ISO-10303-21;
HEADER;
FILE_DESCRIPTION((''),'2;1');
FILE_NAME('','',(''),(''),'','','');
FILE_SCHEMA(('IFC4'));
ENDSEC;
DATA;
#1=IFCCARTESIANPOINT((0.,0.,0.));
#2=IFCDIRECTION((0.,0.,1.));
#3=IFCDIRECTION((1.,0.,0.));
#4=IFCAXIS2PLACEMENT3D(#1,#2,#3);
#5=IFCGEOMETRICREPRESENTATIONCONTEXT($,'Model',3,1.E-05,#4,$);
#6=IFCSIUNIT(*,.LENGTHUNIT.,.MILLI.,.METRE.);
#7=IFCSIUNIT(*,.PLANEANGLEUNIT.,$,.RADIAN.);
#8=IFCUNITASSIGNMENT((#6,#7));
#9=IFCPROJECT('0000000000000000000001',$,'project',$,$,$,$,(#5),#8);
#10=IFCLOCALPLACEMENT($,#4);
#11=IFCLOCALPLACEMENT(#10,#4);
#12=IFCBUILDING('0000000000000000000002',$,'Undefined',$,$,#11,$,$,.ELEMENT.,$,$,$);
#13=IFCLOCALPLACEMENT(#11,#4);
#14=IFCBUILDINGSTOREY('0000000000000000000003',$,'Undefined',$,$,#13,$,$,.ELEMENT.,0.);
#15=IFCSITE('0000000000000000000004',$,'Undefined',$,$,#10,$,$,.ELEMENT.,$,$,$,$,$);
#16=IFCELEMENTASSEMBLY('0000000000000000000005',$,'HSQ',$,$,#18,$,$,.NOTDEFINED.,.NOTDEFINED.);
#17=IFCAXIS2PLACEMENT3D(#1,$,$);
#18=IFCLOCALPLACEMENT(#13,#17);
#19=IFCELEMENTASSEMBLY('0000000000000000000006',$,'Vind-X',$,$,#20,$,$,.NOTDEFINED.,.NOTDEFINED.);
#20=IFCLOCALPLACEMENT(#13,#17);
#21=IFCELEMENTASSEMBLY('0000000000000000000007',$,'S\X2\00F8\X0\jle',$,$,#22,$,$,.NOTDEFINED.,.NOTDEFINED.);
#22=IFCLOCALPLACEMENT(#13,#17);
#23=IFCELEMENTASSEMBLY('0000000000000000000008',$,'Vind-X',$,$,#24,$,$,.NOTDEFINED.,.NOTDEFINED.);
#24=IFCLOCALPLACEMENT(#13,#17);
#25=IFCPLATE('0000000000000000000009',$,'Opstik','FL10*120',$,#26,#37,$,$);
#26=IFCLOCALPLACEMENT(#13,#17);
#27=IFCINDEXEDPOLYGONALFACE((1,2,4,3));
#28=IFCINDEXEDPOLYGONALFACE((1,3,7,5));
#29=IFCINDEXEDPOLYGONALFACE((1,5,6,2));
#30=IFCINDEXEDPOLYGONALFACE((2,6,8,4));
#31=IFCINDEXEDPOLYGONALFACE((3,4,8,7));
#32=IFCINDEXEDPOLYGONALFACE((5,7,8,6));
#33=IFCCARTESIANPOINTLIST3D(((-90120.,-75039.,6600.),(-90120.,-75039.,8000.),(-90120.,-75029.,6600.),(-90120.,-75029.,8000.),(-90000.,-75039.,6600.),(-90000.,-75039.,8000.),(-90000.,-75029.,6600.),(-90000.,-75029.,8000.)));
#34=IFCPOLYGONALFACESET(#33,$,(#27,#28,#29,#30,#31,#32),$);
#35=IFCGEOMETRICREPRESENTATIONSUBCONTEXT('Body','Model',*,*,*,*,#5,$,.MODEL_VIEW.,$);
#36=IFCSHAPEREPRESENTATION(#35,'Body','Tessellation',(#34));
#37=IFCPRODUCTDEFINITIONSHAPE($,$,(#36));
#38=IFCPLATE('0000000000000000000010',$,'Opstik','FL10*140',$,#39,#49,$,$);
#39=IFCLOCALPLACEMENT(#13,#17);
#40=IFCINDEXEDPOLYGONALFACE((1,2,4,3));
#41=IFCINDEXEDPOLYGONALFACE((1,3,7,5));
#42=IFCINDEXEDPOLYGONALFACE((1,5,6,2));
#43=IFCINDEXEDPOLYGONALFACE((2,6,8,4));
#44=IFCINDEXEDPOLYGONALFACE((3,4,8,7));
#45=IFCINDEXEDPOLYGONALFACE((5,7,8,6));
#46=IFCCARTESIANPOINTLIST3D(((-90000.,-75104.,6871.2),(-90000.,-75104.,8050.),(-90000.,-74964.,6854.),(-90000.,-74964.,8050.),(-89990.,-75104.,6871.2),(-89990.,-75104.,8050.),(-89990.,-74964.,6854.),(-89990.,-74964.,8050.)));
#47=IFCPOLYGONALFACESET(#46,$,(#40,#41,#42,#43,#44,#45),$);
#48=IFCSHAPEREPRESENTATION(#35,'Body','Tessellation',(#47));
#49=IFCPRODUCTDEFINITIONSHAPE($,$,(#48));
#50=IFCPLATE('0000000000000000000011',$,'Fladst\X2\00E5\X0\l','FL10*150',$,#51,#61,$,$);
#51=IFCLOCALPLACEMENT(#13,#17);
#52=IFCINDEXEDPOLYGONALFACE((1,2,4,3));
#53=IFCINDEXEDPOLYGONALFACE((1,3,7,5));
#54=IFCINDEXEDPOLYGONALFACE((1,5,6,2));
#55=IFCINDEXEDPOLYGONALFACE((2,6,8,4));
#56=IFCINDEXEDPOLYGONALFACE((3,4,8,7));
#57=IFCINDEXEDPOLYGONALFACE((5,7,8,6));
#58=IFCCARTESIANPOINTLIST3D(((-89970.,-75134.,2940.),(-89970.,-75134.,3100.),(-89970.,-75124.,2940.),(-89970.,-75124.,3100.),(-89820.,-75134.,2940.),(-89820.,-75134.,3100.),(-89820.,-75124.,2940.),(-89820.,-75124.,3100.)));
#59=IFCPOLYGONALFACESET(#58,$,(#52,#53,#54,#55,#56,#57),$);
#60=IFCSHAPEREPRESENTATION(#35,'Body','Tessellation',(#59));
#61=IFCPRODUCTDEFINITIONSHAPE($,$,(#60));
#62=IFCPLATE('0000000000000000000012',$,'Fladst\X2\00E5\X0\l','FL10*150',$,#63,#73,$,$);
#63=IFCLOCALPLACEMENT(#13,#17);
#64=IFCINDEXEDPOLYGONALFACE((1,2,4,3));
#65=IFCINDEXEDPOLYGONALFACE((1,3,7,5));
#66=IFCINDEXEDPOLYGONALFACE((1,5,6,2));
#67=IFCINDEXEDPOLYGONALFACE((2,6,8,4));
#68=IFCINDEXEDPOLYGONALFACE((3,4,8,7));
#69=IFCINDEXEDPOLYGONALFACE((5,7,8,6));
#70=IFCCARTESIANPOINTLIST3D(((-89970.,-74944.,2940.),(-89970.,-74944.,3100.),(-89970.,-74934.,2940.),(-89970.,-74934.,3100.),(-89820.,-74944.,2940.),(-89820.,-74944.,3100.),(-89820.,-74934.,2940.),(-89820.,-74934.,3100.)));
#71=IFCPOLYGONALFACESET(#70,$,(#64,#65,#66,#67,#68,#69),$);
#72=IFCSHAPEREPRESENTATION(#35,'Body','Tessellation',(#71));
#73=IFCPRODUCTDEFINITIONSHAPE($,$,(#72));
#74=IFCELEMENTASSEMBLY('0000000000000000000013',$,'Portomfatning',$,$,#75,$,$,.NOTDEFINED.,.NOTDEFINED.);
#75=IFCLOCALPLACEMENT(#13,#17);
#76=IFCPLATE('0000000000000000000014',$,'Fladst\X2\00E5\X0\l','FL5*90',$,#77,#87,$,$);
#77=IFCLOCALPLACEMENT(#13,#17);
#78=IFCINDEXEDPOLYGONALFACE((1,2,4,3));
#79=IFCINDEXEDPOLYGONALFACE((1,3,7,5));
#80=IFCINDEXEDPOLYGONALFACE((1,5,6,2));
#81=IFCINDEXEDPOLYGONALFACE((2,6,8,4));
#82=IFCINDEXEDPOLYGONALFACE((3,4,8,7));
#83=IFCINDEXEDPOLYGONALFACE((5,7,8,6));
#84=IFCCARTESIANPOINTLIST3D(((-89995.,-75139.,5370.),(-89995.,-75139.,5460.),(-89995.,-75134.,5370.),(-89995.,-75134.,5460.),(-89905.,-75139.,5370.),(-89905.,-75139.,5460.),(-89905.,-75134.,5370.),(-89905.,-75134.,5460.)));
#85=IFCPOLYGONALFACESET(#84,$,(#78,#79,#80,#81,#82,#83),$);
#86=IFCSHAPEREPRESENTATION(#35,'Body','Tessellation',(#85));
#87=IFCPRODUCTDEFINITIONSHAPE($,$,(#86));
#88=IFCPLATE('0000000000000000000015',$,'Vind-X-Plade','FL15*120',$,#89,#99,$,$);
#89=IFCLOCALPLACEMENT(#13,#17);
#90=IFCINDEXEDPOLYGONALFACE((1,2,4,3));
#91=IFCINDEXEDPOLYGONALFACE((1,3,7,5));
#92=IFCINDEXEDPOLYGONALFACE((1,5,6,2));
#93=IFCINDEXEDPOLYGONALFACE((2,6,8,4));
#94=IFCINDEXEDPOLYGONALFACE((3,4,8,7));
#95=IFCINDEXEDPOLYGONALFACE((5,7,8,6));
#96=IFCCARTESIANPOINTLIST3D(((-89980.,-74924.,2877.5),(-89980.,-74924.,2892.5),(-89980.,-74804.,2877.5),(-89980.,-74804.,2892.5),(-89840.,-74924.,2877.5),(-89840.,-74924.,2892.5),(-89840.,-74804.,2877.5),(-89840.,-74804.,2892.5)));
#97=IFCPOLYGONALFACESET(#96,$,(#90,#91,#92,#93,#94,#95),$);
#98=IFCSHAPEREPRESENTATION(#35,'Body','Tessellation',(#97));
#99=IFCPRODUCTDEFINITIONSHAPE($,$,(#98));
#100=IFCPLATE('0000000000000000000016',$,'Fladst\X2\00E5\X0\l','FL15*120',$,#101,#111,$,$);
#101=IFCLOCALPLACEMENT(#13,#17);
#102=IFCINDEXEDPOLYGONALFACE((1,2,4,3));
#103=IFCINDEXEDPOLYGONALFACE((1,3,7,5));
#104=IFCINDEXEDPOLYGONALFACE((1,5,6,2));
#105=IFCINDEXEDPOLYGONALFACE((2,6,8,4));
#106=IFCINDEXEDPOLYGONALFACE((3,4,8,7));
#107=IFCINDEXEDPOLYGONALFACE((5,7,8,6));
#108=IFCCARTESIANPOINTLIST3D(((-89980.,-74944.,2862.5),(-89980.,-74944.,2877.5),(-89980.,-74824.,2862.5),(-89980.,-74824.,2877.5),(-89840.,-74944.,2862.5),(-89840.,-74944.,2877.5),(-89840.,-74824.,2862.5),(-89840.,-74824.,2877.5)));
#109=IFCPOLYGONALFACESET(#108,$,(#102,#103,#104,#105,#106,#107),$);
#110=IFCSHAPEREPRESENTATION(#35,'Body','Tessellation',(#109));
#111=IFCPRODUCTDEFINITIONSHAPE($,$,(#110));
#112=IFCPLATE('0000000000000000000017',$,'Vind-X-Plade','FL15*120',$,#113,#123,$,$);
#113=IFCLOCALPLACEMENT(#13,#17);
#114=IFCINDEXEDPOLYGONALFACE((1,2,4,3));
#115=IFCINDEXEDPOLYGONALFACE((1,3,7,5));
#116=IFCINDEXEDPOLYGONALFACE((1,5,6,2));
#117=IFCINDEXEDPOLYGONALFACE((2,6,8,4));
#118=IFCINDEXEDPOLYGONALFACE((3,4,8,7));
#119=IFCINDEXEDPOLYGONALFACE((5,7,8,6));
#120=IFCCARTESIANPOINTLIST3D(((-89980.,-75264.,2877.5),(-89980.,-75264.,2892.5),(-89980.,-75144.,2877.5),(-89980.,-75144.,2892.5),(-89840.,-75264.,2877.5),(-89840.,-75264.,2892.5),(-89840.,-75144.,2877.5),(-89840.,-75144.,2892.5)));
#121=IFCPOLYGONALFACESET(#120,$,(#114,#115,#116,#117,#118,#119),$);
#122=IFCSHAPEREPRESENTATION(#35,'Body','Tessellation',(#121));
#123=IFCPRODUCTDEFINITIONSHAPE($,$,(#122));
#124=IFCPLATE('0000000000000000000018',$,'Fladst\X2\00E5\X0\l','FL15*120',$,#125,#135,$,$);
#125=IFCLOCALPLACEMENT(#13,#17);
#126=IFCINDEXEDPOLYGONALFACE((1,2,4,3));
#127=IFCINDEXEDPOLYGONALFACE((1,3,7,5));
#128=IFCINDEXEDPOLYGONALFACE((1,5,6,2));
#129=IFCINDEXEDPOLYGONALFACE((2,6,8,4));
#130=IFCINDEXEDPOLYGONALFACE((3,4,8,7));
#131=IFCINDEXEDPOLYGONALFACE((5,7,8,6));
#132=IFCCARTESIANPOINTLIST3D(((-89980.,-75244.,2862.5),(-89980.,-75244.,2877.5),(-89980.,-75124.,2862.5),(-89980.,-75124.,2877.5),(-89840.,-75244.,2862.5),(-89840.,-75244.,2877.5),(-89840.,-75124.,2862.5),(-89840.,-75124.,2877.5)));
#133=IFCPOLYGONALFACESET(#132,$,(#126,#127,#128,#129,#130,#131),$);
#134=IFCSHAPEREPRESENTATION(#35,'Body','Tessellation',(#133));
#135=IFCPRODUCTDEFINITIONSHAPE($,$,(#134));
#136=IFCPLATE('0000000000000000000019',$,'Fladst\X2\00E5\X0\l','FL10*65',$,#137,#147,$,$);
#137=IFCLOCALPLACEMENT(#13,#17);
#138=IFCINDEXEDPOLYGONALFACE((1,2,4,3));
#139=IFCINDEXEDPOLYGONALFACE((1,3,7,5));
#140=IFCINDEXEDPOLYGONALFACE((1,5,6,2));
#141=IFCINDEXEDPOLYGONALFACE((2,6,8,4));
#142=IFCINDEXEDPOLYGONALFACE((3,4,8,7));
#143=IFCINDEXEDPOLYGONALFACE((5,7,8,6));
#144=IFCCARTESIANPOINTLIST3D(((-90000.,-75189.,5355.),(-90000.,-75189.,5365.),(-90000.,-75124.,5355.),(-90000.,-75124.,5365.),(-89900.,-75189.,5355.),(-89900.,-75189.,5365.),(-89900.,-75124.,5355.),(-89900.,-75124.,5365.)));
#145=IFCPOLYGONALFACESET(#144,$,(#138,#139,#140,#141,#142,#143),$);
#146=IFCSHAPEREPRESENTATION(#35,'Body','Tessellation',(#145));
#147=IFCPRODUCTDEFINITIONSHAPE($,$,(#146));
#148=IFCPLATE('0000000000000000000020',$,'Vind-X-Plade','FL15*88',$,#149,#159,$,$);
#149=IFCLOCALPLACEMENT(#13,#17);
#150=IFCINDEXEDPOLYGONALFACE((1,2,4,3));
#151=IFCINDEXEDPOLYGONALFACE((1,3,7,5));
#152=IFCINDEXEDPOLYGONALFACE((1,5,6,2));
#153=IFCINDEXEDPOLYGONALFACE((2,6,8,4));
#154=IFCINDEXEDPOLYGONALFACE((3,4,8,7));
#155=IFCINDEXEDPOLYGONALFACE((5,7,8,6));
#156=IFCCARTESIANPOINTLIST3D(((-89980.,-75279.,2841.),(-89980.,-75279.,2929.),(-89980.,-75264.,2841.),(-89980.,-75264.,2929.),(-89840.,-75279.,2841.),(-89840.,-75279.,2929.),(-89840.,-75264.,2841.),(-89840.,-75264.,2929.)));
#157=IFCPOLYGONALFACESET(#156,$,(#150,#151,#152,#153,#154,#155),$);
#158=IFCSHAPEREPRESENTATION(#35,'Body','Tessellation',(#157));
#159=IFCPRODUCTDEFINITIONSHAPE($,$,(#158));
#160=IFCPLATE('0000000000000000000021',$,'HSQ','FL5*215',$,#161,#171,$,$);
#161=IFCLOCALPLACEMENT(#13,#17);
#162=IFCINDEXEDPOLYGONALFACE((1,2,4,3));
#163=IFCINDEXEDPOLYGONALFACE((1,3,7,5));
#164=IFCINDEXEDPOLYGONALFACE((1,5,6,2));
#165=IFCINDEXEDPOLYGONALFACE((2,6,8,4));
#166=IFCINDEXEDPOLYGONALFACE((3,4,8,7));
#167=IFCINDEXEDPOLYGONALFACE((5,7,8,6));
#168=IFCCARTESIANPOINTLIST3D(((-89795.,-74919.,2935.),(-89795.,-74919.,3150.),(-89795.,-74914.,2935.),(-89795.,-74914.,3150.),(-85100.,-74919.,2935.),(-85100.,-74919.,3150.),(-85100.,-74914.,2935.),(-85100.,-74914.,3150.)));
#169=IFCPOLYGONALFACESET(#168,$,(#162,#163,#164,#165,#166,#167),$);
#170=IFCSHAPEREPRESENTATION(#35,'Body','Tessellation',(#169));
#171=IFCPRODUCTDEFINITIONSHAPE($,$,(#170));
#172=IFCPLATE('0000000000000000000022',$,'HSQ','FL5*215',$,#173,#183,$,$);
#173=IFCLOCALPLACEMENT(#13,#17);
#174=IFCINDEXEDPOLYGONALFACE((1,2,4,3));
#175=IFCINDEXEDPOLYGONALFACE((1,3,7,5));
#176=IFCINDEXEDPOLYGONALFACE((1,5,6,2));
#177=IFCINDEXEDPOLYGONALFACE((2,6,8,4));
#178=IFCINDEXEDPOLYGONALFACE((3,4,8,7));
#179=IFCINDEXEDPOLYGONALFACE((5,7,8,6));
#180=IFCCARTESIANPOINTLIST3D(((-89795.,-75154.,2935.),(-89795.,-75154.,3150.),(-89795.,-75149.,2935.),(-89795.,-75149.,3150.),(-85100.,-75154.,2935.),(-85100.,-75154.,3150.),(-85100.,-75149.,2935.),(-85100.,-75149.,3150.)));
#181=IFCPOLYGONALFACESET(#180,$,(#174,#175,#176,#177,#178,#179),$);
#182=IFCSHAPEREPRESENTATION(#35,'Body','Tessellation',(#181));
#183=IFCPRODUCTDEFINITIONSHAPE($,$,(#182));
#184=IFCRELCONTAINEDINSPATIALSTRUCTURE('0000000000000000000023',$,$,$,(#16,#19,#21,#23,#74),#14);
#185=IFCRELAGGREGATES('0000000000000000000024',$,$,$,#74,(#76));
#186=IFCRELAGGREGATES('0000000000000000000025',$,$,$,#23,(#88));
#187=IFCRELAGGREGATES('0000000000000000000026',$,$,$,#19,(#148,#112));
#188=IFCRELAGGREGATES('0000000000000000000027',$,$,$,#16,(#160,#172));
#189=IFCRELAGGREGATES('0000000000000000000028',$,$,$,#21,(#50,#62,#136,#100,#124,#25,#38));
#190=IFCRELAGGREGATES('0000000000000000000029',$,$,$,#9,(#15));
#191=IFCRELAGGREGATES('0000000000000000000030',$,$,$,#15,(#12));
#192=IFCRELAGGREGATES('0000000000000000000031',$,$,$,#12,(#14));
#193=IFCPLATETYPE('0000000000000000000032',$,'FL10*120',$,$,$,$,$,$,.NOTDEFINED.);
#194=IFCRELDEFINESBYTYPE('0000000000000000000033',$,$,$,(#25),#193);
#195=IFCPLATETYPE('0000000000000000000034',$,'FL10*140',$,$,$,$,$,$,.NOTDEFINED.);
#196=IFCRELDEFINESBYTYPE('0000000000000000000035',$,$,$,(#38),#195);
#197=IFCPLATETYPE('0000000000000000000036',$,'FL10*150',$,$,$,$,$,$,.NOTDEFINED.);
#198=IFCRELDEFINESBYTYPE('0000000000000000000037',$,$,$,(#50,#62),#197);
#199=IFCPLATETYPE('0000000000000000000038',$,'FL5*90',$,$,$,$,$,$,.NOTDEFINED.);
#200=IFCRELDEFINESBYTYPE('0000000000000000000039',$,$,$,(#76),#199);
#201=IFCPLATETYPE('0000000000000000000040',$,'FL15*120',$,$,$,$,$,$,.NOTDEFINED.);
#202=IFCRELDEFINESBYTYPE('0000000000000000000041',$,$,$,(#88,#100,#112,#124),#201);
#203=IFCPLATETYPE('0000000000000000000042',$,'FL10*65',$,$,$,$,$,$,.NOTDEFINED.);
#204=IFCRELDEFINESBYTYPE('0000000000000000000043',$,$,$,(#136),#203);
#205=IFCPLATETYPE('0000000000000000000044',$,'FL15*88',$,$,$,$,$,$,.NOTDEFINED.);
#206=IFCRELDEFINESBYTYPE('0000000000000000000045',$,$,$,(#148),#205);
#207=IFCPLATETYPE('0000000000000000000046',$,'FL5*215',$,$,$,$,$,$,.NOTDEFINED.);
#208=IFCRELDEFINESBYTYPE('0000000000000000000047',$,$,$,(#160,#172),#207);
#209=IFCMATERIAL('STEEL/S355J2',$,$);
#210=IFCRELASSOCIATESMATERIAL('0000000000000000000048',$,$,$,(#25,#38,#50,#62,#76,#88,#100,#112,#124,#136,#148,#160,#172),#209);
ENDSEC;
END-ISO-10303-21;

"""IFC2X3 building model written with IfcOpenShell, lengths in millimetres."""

from ifc_helpers import new_model, si_unit, frame, origin_with_axes, place, context, subcontext, project, spatial, polyline, outline, extrude, material, type_object, element, aggregate, save


model = new_model("IFC2X3")

# Units and contexts
model_context = context("Model", 3, precision=1e-05, world=origin_with_axes())
body_context = subcontext(model_context, "Body", "Model", "MODEL_VIEW")
ifc_project = project(units=[si_unit("LENGTHUNIT", "METRE", prefix="MILLI"), si_unit("PLANEANGLEUNIT", "RADIAN")], contexts=[model_context])

# Site, building, storey
site_placement = place(None, origin_with_axes())
site = spatial("IfcSite", under=ifc_project, at=site_placement, Name="Undefined", CompositionType="ELEMENT")
building_placement = place(site_placement, origin_with_axes())
building = spatial("IfcBuilding", under=site, at=building_placement, Name="Undefined", CompositionType="ELEMENT")
storey_placement = place(building_placement, origin_with_axes())
storey = spatial("IfcBuildingStorey", under=building, at=storey_placement, Name="Undefined", CompositionType="ELEMENT", Elevation=0.0)

# Element assembly
assembly_1_placement = place(storey_placement, origin_with_axes())
assembly_1 = element("IfcElementAssembly", 1, at=assembly_1_placement, inside=storey, Name="HSQ", AssemblyPlace="NOTDEFINED", PredefinedType="NOTDEFINED")

# Element assembly
assembly_2_placement = place(storey_placement, origin_with_axes())
assembly_2 = element("IfcElementAssembly", 2, at=assembly_2_placement, inside=storey, Name="Vind-X", AssemblyPlace="NOTDEFINED", PredefinedType="NOTDEFINED")

# Element assembly
assembly_3_placement = place(storey_placement, origin_with_axes())
assembly_3 = element("IfcElementAssembly", 3, at=assembly_3_placement, inside=storey, Name="Søjle", AssemblyPlace="NOTDEFINED", PredefinedType="NOTDEFINED")

# Element assembly
assembly_4_placement = place(storey_placement, origin_with_axes())
assembly_4 = element("IfcElementAssembly", 4, at=assembly_4_placement, inside=storey, Name="Vind-X", AssemblyPlace="NOTDEFINED", PredefinedType="NOTDEFINED")

# Shared definitions
ifc_material_1 = material(Name="STEEL/S355J2")

# Plates
plate_type_1 = type_object("IfcPlateType", Name="FL10*120", PredefinedType="NOTDEFINED")
plate_1_placement = place(assembly_3_placement, frame((-90000.0, -75034.0, 6600.0), z_axis=(0.0, -1.0, 0.0), x_axis=(0.0, 0.0, 1.0)))
plate_1 = element("IfcPlate", 5, at=plate_1_placement, type_object=plate_type_1, material=ifc_material_1, Name="Opstik", Description="FL10*120", context=body_context, shape_type="SweptSolid", body=[
    extrude(outline(polyline([(0.0, 0.0), (1400.0, 0.0), (1400.0, 120.0), (1400.0, 120.0), (0.0, 120.0), (0.0, 120.0), (0.0, 0.0)])), frame((0.0, 0.0, -5.0), z_axis=(0.0, 0.0, 1.0), x_axis=(1.0, 0.0, 0.0)), (0.0, 0.0, 1.0), 10.0),
])
plate_type_2 = type_object("IfcPlateType", Name="FL10*140", PredefinedType="NOTDEFINED")
plate_2_placement = place(assembly_3_placement, frame((-89995.0, -75104.0, 6871.2), z_axis=(-1.0, 0.0, 0.0), x_axis=(0.0, 0.0, 1.0)))
plate_2 = element("IfcPlate", 6, at=plate_2_placement, type_object=plate_type_2, material=ifc_material_1, Name="Opstik", Description="FL10*140", context=body_context, shape_type="SweptSolid", body=[
    extrude(outline(polyline([(0.0, 0.0), (1178.8, 0.0), (1178.8, 0.0), (1178.8, 140.0), (1178.8, 140.0), (-17.2, 140.0), (0.0, 0.0)])), frame((0.0, 0.0, -5.0), z_axis=(0.0, 0.0, 1.0), x_axis=(1.0, 0.0, 0.0)), (0.0, 0.0, 1.0), 10.0),
])
plate_type_3 = type_object("IfcPlateType", Name="FL10*150", PredefinedType="NOTDEFINED")
plate_3_placement = place(assembly_3_placement, frame((-89820.0, -75129.0, 3100.0), z_axis=(0.0, -1.0, 0.0), x_axis=(-1.0, 0.0, 0.0)))
plate_3 = element("IfcPlate", 7, at=plate_3_placement, type_object=plate_type_3, material=ifc_material_1, Name="Fladstål", Description="FL10*150", context=body_context, shape_type="SweptSolid", body=[
    extrude(outline(polyline([(0.0, 0.0), (150.0, 0.0), (150.0, 160.0), (0.0, 160.0), (0.0, 0.0)])), frame((0.0, 0.0, -5.0), z_axis=(0.0, 0.0, 1.0), x_axis=(1.0, 0.0, 0.0)), (0.0, 0.0, 1.0), 10.0),
])
plate_4_placement = place(assembly_3_placement, frame((-89820.0, -74939.0, 3100.0), z_axis=(0.0, -1.0, 0.0), x_axis=(-1.0, 0.0, 0.0)))
plate_4 = element("IfcPlate", 8, at=plate_4_placement, type_object=plate_type_3, material=ifc_material_1, Name="Fladstål", Description="FL10*150", context=body_context, shape_type="SweptSolid", body=[
    extrude(outline(polyline([(0.0, 0.0), (150.0, 0.0), (150.0, 160.0), (0.0, 160.0), (0.0, 0.0)])), frame((0.0, 0.0, -5.0), z_axis=(0.0, 0.0, 1.0), x_axis=(1.0, 0.0, 0.0)), (0.0, 0.0, 1.0), 10.0),
])

# Element assembly, plate
assembly_5_placement = place(storey_placement, origin_with_axes())
assembly_5 = element("IfcElementAssembly", 9, at=assembly_5_placement, inside=storey, Name="Portomfatning", AssemblyPlace="NOTDEFINED", PredefinedType="NOTDEFINED")
plate_type_4 = type_object("IfcPlateType", Name="FL5*90", PredefinedType="NOTDEFINED")
plate_5_placement = place(assembly_5_placement, frame((-89995.0, -75136.5, 5370.0), z_axis=(0.000185, 1.0, 0.0), x_axis=(0.0, 0.0, 1.0)))
plate_5 = element("IfcPlate", 10, at=plate_5_placement, type_object=plate_type_4, material=ifc_material_1, Name="Fladstål", Description="FL5*90", context=body_context, shape_type="SweptSolid", body=[
    extrude(outline(polyline([(0.0, 0.0), (90.0, 0.0), (90.0, 90.0), (0.0, 90.0), (0.0, 0.0)])), frame((0.0, 0.0, -2.5), z_axis=(0.0, 0.0, 1.0), x_axis=(1.0, 0.0, 0.0)), (0.0, 0.0, 1.0), 5.0),
])
aggregate(assembly_5, [plate_5])

# Plates
plate_type_5 = type_object("IfcPlateType", Name="FL15*120", PredefinedType="NOTDEFINED")
plate_6_placement = place(assembly_4_placement, frame((-89910.0, -74924.0, 2885.0), z_axis=(0.0, 0.0, -1.0), x_axis=(0.0, 1.0, 0.0)))
plate_6 = element("IfcPlate", 11, at=plate_6_placement, type_object=plate_type_5, material=ifc_material_1, Name="Vind-X-Plade", Description="FL15*120", context=body_context, shape_type="SweptSolid", body=[
    extrude(outline(polyline([(0.0, -70.0), (0.0, 70.0), (120.0, 70.0), (120.0, -70.0), (0.0, -70.0)])), frame((0.0, 0.0, -7.5), z_axis=(0.0, 0.0, 1.0), x_axis=(1.0, 0.0, 0.0)), (0.0, 0.0, 1.0), 15.0),
])
plate_7_placement = place(assembly_3_placement, frame((-89980.0, -74944.0, 2870.0), z_axis=(0.0, 0.0, 1.0), x_axis=(1.0, 0.0, 0.0)))
plate_7 = element("IfcPlate", 12, at=plate_7_placement, type_object=plate_type_5, material=ifc_material_1, Name="Fladstål", Description="FL15*120", context=body_context, shape_type="SweptSolid", body=[
    extrude(outline(polyline([(0.0, 0.0), (140.0, 0.0), (140.0, 120.0), (0.0, 120.0), (0.0, 0.0)])), frame((0.0, 0.0, -7.5), z_axis=(0.0, 0.0, 1.0), x_axis=(1.0, 0.0, 0.0)), (0.0, 0.0, 1.0), 15.0),
])
plate_8_placement = place(assembly_2_placement, frame((-89910.0, -75144.0, 2885.0), z_axis=(0.0, 0.0, -1.0), x_axis=(0.0, -1.0, 0.0)))
plate_8 = element("IfcPlate", 13, at=plate_8_placement, type_object=plate_type_5, material=ifc_material_1, Name="Vind-X-Plade", Description="FL15*120", context=body_context, shape_type="SweptSolid", body=[
    extrude(outline(polyline([(0.0, -70.0), (0.0, 70.0), (120.0, 70.0), (120.0, -70.0), (0.0, -70.0)])), frame((0.0, 0.0, -7.5), z_axis=(0.0, 0.0, 1.0), x_axis=(1.0, 0.0, 0.0)), (0.0, 0.0, 1.0), 15.0),
])
plate_9_placement = place(assembly_3_placement, frame((-89840.0, -75124.0, 2870.0), z_axis=(0.0, 0.0, 1.0), x_axis=(-1.0, 0.0, 0.0)))
plate_9 = element("IfcPlate", 14, at=plate_9_placement, type_object=plate_type_5, material=ifc_material_1, Name="Fladstål", Description="FL15*120", context=body_context, shape_type="SweptSolid", body=[
    extrude(outline(polyline([(0.0, 0.0), (140.0, 0.0), (140.0, 120.0), (0.0, 120.0), (0.0, 0.0)])), frame((0.0, 0.0, -7.5), z_axis=(0.0, 0.0, 1.0), x_axis=(1.0, 0.0, 0.0)), (0.0, 0.0, 1.0), 15.0),
])
plate_type_6 = type_object("IfcPlateType", Name="FL10*65", PredefinedType="NOTDEFINED")
plate_10_placement = place(assembly_3_placement, frame((-90000.0, -75124.0, 5360.0), z_axis=(0.0, 0.0, 1.0), x_axis=(0.0, -1.0, 0.0)))
plate_10 = element("IfcPlate", 15, at=plate_10_placement, type_object=plate_type_6, material=ifc_material_1, Name="Fladstål", Description="FL10*65", context=body_context, shape_type="SweptSolid", body=[
    extrude(outline(polyline([(0.0, 0.0), (65.0, 0.0), (65.0, 100.0), (0.0, 100.0), (0.0, 0.0)])), frame((0.0, 0.0, -5.0), z_axis=(0.0, 0.0, 1.0), x_axis=(1.0, 0.0, 0.0)), (0.0, 0.0, 1.0), 10.0),
])
plate_type_7 = type_object("IfcPlateType", Name="FL15*88", PredefinedType="NOTDEFINED")
plate_11_placement = place(assembly_2_placement, frame((-89840.0, -75271.5, 2841.0), z_axis=(0.0, 1.0, 0.0), x_axis=(-1.0, 0.0, 0.0)))
plate_11 = element("IfcPlate", 16, at=plate_11_placement, type_object=plate_type_7, material=ifc_material_1, Name="Vind-X-Plade", Description="FL15*88", context=body_context, shape_type="SweptSolid", body=[
    extrude(outline(polyline([(0.0, 0.0), (140.0, 0.0), (140.0, 88.0), (0.0, 88.0), (0.0, 0.0)])), frame((0.0, 0.0, -7.5), z_axis=(0.0, 0.0, 1.0), x_axis=(1.0, 0.0, 0.0)), (0.0, 0.0, 1.0), 15.0),
])
plate_type_8 = type_object("IfcPlateType", Name="FL5*215", PredefinedType="NOTDEFINED")
plate_12_placement = place(assembly_1_placement, frame((-89795.0, -74916.5, 3042.5), z_axis=(0.0, -1.0, 0.0), x_axis=(1.0, 0.0, 0.0)))
plate_12 = element("IfcPlate", 17, at=plate_12_placement, type_object=plate_type_8, material=ifc_material_1, Name="HSQ", Description="FL5*215", context=body_context, shape_type="SweptSolid", body=[
    extrude(outline(polyline([(0.0, -107.5), (0.0, 107.5), (4695.0, 107.5), (4695.0, -107.5), (0.0, -107.5)])), frame((0.0, 0.0, -2.5), z_axis=(0.0, 0.0, 1.0), x_axis=(1.0, 0.0, 0.0)), (0.0, 0.0, 1.0), 5.0),
])
plate_13_placement = place(assembly_1_placement, frame((-89795.0, -75151.5, 3042.5), z_axis=(0.0, -1.0, 0.0), x_axis=(1.0, 0.0, 0.0)))
plate_13 = element("IfcPlate", 18, at=plate_13_placement, type_object=plate_type_8, material=ifc_material_1, Name="HSQ", Description="FL5*215", context=body_context, shape_type="SweptSolid", body=[
    extrude(outline(polyline([(0.0, -107.5), (0.0, 107.5), (4695.0, 107.5), (4695.0, -107.5), (0.0, -107.5)])), frame((0.0, 0.0, -2.5), z_axis=(0.0, 0.0, 1.0), x_axis=(1.0, 0.0, 0.0)), (0.0, 0.0, 1.0), 5.0),
])

aggregate(assembly_4, [plate_6])
aggregate(assembly_2, [plate_11, plate_8])
aggregate(assembly_1, [plate_12, plate_13])
aggregate(assembly_3, [plate_3, plate_4, plate_10, plate_7, plate_9, plate_1, plate_2])

save(model, "model.ifc")
